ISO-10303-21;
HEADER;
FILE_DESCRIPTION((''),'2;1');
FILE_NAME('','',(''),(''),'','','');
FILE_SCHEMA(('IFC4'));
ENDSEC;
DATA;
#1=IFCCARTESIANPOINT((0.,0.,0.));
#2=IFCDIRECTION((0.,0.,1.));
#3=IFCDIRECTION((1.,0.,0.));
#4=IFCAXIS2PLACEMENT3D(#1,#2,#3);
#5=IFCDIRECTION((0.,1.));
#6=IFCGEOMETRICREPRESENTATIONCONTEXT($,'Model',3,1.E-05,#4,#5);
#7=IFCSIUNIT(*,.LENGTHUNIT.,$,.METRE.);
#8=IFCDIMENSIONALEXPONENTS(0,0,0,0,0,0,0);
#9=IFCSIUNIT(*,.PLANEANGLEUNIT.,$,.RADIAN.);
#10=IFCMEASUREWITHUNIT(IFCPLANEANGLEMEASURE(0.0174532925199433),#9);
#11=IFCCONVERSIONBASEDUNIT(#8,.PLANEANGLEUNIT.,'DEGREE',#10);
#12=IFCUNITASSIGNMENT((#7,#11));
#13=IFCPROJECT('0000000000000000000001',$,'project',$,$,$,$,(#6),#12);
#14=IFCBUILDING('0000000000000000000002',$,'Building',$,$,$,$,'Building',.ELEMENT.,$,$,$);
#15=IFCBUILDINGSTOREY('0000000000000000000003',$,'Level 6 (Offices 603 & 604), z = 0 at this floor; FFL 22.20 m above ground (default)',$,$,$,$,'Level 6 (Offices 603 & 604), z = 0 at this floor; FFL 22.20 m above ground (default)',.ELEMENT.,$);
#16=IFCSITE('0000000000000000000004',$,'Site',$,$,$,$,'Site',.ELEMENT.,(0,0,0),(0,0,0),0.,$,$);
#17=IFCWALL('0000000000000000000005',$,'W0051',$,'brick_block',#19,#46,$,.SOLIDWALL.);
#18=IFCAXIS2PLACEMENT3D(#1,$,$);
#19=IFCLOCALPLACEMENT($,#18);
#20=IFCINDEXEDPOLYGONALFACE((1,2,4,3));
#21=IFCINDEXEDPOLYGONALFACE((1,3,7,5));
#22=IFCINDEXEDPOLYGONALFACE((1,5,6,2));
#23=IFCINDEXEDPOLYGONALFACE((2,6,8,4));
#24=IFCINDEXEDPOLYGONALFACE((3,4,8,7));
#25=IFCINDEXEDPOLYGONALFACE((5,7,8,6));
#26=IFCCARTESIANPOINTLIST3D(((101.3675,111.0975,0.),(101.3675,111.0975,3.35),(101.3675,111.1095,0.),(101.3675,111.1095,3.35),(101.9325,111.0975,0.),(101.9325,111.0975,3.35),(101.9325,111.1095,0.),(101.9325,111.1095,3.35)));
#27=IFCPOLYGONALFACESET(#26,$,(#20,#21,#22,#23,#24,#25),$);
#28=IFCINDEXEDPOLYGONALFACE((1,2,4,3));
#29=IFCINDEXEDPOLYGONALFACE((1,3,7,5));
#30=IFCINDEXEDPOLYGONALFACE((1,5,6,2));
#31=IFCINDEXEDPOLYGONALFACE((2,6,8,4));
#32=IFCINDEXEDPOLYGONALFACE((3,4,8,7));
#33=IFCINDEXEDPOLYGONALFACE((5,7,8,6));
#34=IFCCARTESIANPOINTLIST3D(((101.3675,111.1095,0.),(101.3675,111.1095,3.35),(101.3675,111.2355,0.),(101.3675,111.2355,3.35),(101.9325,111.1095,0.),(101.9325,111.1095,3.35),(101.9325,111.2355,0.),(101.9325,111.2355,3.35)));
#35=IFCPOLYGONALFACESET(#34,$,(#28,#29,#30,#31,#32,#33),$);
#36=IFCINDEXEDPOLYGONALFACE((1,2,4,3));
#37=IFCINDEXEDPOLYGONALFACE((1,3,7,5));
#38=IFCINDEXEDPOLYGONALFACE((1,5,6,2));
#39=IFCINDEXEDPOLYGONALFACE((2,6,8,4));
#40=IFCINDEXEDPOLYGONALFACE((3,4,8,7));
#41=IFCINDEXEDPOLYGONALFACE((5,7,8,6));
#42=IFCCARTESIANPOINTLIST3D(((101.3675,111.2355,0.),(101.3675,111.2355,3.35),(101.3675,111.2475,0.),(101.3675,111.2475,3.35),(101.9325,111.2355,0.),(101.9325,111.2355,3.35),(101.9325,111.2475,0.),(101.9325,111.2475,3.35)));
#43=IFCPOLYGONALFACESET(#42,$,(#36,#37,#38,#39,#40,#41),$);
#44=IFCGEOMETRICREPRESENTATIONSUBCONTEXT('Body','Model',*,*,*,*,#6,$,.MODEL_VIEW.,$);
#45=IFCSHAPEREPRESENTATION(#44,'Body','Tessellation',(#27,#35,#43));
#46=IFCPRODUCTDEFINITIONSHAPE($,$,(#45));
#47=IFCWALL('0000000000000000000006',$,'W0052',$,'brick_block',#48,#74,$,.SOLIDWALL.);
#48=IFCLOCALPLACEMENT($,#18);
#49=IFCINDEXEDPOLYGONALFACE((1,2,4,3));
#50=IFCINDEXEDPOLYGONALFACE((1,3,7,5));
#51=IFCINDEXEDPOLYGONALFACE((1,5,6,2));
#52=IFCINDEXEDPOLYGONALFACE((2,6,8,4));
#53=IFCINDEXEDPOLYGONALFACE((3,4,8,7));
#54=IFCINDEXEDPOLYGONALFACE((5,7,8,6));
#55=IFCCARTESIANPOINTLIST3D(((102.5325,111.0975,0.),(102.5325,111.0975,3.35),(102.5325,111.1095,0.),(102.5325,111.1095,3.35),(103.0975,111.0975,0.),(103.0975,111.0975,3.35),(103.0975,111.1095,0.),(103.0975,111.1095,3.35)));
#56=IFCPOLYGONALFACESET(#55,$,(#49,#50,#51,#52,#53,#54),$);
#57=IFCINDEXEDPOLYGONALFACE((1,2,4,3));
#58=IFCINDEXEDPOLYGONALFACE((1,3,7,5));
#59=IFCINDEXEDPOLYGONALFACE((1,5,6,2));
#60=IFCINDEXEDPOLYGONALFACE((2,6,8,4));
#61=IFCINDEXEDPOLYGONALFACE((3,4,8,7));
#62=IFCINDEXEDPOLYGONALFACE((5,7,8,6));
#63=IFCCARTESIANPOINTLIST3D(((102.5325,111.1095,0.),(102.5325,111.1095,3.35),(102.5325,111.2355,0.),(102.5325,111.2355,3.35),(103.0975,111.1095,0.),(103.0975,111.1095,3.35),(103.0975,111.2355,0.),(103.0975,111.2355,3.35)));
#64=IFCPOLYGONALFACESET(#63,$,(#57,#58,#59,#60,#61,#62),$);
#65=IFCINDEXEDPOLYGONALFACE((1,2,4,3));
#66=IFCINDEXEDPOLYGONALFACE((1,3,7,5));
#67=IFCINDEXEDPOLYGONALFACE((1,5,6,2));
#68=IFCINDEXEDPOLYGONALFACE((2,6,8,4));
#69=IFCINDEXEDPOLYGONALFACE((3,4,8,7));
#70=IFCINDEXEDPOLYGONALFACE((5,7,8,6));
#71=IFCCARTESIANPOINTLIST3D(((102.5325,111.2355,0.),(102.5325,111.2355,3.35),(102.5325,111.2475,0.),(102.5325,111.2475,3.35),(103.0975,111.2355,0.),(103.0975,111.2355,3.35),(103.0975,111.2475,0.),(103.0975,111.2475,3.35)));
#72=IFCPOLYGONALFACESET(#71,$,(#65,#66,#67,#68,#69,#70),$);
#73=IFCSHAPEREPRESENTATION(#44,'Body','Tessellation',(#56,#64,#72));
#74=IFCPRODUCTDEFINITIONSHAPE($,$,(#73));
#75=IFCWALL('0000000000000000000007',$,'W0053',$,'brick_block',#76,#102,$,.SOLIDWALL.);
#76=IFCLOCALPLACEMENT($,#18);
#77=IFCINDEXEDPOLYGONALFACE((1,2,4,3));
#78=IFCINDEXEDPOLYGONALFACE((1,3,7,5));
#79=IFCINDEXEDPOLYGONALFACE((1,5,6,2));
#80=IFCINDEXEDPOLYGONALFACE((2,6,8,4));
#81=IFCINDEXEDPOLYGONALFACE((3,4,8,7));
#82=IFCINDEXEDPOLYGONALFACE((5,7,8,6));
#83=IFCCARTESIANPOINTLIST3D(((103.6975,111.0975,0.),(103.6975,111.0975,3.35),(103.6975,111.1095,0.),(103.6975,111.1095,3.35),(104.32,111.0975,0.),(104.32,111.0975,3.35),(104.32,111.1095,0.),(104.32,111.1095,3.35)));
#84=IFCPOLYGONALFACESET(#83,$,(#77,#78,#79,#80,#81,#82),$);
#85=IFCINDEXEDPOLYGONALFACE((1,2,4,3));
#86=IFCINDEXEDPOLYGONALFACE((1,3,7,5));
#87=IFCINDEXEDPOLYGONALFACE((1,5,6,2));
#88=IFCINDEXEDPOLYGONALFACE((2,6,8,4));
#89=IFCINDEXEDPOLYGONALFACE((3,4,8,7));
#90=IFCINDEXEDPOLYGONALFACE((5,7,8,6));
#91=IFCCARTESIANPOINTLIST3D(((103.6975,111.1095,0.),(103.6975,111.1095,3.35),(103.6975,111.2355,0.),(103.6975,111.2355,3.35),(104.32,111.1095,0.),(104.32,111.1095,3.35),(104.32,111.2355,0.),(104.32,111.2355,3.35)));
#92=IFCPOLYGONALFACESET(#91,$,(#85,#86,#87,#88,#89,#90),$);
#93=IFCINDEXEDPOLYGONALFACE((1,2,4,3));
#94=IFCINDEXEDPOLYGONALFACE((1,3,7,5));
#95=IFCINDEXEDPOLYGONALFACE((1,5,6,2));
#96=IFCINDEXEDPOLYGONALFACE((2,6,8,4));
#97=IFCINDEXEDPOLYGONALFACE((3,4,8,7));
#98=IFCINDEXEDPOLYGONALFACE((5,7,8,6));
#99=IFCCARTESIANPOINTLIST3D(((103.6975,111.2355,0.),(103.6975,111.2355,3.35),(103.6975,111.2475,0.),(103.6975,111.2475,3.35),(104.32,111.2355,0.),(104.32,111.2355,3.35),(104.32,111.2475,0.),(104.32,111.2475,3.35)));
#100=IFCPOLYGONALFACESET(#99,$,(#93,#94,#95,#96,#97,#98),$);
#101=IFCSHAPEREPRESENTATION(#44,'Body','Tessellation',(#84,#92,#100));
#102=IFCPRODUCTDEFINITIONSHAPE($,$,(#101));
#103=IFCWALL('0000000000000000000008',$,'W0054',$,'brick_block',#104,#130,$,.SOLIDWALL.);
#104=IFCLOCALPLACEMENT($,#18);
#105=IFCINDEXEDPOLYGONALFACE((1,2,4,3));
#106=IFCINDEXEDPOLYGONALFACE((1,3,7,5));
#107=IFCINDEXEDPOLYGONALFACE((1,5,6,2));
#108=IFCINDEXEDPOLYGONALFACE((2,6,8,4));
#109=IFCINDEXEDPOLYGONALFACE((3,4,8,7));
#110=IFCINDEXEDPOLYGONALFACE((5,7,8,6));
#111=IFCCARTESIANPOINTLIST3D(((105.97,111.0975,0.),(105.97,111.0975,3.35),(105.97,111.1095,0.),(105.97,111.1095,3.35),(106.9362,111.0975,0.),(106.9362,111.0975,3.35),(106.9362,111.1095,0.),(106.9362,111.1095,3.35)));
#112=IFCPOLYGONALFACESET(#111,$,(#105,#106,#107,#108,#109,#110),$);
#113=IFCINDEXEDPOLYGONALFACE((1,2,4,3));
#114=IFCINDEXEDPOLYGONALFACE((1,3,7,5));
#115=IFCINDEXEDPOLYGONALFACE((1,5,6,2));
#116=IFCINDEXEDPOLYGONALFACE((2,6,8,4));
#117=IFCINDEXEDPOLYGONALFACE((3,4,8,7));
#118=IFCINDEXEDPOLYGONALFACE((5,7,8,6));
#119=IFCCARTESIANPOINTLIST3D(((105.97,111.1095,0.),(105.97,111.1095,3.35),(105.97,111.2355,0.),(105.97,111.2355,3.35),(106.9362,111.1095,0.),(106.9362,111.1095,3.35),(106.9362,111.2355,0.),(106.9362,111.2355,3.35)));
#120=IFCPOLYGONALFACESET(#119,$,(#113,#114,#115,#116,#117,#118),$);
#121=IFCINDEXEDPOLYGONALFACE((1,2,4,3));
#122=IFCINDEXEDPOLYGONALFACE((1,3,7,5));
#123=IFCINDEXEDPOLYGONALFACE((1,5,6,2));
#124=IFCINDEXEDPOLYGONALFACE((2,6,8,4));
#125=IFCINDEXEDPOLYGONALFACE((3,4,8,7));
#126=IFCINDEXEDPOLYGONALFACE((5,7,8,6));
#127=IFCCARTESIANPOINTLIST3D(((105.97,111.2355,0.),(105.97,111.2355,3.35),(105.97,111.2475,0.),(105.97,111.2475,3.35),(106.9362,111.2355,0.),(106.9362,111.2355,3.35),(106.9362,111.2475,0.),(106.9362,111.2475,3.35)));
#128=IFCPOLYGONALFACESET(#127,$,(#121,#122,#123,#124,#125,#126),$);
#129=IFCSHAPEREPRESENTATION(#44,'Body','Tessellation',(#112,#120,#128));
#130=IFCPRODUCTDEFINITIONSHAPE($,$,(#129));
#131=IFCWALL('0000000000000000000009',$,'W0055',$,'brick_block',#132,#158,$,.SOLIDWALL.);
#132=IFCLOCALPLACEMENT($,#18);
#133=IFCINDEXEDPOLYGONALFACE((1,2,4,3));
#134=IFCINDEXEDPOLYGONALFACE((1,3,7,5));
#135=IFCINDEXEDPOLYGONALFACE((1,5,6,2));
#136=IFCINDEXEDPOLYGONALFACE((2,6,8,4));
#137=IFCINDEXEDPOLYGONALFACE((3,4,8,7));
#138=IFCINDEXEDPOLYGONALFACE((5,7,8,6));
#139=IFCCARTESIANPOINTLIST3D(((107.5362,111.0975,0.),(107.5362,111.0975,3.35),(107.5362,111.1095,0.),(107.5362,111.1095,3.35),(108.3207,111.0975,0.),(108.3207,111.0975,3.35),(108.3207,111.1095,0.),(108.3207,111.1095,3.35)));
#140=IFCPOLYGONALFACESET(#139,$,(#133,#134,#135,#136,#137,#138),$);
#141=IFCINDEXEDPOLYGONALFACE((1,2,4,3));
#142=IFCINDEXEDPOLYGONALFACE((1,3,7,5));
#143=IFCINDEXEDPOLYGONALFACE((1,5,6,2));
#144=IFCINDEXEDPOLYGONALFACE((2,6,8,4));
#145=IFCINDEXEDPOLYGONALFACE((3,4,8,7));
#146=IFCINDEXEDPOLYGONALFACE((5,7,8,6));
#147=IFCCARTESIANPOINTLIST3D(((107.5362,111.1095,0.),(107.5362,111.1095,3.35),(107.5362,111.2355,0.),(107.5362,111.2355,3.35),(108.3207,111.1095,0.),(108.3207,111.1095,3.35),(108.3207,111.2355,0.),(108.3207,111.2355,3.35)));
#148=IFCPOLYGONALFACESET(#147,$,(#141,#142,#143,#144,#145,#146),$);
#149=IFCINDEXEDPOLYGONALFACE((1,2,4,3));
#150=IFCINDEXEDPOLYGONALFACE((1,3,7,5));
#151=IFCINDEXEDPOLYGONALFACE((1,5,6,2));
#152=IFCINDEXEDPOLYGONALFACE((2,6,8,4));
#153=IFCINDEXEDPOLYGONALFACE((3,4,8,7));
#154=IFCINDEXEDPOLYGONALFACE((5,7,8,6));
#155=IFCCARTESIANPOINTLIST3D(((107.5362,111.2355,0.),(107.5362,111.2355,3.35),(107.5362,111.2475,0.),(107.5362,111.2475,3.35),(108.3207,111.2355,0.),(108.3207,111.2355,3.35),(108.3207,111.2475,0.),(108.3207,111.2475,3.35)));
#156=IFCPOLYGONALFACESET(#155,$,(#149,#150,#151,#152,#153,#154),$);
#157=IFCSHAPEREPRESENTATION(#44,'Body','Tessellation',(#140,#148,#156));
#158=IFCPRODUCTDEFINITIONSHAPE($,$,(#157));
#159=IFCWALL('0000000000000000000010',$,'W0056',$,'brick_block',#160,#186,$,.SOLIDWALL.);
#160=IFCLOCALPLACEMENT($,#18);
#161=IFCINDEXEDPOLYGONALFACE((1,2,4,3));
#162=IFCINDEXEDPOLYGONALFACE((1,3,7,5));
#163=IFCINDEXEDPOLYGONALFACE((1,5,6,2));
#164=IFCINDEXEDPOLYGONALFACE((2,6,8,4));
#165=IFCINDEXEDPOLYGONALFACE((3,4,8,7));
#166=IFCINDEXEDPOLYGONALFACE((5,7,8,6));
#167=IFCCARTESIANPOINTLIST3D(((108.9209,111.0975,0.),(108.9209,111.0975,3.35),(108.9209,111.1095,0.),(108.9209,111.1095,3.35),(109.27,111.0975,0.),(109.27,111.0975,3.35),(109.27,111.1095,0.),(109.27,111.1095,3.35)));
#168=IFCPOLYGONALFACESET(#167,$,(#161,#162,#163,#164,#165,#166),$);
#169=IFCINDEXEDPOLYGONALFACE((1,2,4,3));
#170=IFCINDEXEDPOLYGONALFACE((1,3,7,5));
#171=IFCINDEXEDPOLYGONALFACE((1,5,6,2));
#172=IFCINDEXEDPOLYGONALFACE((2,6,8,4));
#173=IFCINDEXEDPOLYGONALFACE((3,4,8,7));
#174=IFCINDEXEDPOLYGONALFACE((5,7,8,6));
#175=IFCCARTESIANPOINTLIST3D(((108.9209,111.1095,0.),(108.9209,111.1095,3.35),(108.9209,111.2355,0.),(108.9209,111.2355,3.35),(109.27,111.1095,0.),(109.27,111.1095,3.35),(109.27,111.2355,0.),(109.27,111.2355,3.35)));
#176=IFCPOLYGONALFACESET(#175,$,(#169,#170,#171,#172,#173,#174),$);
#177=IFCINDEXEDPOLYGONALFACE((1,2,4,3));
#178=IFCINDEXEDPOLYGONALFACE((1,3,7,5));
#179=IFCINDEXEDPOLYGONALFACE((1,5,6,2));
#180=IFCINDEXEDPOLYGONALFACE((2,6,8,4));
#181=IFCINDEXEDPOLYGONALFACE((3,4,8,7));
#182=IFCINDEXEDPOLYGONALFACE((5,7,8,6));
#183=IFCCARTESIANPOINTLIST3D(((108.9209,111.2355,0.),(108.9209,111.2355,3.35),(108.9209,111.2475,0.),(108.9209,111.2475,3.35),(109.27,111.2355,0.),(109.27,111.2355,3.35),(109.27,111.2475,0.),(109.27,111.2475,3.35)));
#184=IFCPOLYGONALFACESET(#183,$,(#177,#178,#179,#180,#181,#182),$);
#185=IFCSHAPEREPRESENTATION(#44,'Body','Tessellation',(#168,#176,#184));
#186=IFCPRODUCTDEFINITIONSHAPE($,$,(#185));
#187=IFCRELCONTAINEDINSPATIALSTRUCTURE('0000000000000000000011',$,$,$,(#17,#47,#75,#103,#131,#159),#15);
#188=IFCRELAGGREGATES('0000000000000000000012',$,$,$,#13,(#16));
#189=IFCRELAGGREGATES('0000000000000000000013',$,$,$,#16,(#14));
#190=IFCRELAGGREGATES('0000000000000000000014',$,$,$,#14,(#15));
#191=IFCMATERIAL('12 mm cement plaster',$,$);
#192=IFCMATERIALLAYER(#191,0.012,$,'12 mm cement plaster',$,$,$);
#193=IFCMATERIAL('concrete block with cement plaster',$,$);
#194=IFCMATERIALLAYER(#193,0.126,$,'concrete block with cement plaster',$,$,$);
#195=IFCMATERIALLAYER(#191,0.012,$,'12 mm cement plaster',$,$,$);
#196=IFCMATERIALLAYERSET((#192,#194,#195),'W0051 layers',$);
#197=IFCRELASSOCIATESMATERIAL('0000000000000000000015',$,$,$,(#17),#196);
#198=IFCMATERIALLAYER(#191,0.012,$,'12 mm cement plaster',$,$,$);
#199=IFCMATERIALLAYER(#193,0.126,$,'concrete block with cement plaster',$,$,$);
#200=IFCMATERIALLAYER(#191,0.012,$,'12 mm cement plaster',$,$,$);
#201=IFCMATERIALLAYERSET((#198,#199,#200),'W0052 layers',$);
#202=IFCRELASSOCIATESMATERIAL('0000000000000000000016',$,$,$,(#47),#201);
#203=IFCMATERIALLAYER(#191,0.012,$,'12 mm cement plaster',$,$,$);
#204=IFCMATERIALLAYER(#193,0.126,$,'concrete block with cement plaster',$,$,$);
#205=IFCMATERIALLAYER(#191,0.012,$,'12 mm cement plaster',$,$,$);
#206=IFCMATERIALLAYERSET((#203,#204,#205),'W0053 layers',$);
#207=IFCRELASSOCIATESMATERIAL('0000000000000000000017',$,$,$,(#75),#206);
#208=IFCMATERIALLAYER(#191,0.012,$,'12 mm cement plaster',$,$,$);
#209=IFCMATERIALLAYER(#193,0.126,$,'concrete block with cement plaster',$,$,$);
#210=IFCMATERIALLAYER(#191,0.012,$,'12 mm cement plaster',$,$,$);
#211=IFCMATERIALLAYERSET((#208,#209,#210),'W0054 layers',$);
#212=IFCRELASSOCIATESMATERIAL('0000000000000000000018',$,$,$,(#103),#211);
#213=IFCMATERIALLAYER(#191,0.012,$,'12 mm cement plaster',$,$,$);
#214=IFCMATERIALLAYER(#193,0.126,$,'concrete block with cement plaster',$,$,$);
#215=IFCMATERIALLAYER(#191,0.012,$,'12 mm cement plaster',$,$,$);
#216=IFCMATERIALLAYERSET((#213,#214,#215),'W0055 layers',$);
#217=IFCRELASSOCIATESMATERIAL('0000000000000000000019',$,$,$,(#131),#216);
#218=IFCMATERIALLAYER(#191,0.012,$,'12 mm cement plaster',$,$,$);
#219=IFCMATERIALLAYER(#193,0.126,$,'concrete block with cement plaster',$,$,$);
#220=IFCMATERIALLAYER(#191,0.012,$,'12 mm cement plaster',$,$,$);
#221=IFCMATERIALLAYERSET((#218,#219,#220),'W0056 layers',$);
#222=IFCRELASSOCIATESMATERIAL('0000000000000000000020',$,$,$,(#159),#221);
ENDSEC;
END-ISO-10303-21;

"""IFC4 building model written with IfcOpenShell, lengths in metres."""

from ifc_helpers import new_model, entity, si_unit, converted_unit, direction, frame, frame_2d, origin_with_axes, origin_2d_with_axis, place, context, subcontext, project, spatial, rectangle, extrude, material, layer, layer_set, layer_usage, element, save


model = new_model("IFC4")

# Units and contexts
model_context = context("Model", 3, precision=1e-05, world=origin_with_axes(), true_north=direction((0.0, 1.0)))
body_context = subcontext(model_context, "Body", "Model", "MODEL_VIEW")
ifc_project = project(units=[si_unit("LENGTHUNIT", "METRE"), converted_unit("PLANEANGLEUNIT", "DEGREE", entity("IfcPlaneAngleMeasure", 0.0174532925199433), si_unit("PLANEANGLEUNIT", "RADIAN"), dimensions=[0, 0, 0, 0, 0, 0, 0])], contexts=[model_context])

# Site, building, storey
site = spatial("IfcSite", under=ifc_project, Name="Site", LongName="Site", CompositionType="ELEMENT", RefLatitude=(0, 0, 0), RefLongitude=(0, 0, 0), RefElevation=0.0)
building = spatial("IfcBuilding", under=site, Name="Building", LongName="Building", CompositionType="ELEMENT")
storey = spatial("IfcBuildingStorey", under=building, Name="Level 6 (Offices 603 & 604), z = 0 at this floor; FFL 22.20 m above ground (default)", LongName="Level 6 (Offices 603 & 604), z = 0 at this floor; FFL 22.20 m above ground (default)", CompositionType="ELEMENT")

# Walls
ifc_material_1 = material(Name="12 mm cement plaster")
ifc_layer_1 = layer(ifc_material_1, 0.012, Name="12 mm cement plaster")
ifc_material_2 = material(Name="concrete block with cement plaster")
ifc_layer_2 = layer(ifc_material_2, 0.126, Name="concrete block with cement plaster")
ifc_layer_3 = layer(ifc_material_1, 0.012, Name="12 mm cement plaster")
ifc_layer_set_1 = layer_set([ifc_layer_1, ifc_layer_2, ifc_layer_3], Name="W0051 layers")
ifc_layer_usage_1 = layer_usage(ifc_layer_set_1, "AXIS2", "POSITIVE", -0.075)
placement = place(None, origin_with_axes())
element("IfcWall", 1, at=placement, inside=storey, material=ifc_layer_usage_1, Name="W0051", ObjectType="brick_block", PredefinedType="SOLIDWALL", context=body_context, shape_type="SweptSolid", body=[
    extrude(rectangle(XDim=0.565, YDim=0.012, at=origin_2d_with_axis()), frame((101.65, 111.1035, 0.0), z_axis=(0.0, 0.0, 1.0), x_axis=(1.0, 0.0, 0.0)), (0.0, 0.0, 1.0), 3.35),
    extrude(rectangle(XDim=0.565, YDim=0.126, at=frame_2d((0.0, 0.069), x_axis=(1.0, 0.0))), frame((101.65, 111.1035, 0.0), z_axis=(0.0, 0.0, 1.0), x_axis=(1.0, 0.0, 0.0)), (0.0, 0.0, 1.0), 3.35),
    extrude(rectangle(XDim=0.565, YDim=0.012, at=frame_2d((0.0, 0.138), x_axis=(1.0, 0.0))), frame((101.65, 111.1035, 0.0), z_axis=(0.0, 0.0, 1.0), x_axis=(1.0, 0.0, 0.0)), (0.0, 0.0, 1.0), 3.35),
])
ifc_layer_4 = layer(ifc_material_1, 0.012, Name="12 mm cement plaster")
ifc_layer_5 = layer(ifc_material_2, 0.126, Name="concrete block with cement plaster")
ifc_layer_6 = layer(ifc_material_1, 0.012, Name="12 mm cement plaster")
ifc_layer_set_2 = layer_set([ifc_layer_4, ifc_layer_5, ifc_layer_6], Name="W0052 layers")
ifc_layer_usage_2 = layer_usage(ifc_layer_set_2, "AXIS2", "POSITIVE", -0.075)
element("IfcWall", 2, at=placement, inside=storey, material=ifc_layer_usage_2, Name="W0052", ObjectType="brick_block", PredefinedType="SOLIDWALL", context=body_context, shape_type="SweptSolid", body=[
    extrude(rectangle(XDim=0.565, YDim=0.012, at=origin_2d_with_axis()), frame((102.815, 111.1035, 0.0), z_axis=(0.0, 0.0, 1.0), x_axis=(1.0, 0.0, 0.0)), (0.0, 0.0, 1.0), 3.35),
    extrude(rectangle(XDim=0.565, YDim=0.126, at=frame_2d((0.0, 0.069), x_axis=(1.0, 0.0))), frame((102.815, 111.1035, 0.0), z_axis=(0.0, 0.0, 1.0), x_axis=(1.0, 0.0, 0.0)), (0.0, 0.0, 1.0), 3.35),
    extrude(rectangle(XDim=0.565, YDim=0.012, at=frame_2d((0.0, 0.138), x_axis=(1.0, 0.0))), frame((102.815, 111.1035, 0.0), z_axis=(0.0, 0.0, 1.0), x_axis=(1.0, 0.0, 0.0)), (0.0, 0.0, 1.0), 3.35),
])
ifc_layer_7 = layer(ifc_material_1, 0.012, Name="12 mm cement plaster")
ifc_layer_8 = layer(ifc_material_2, 0.126, Name="concrete block with cement plaster")
ifc_layer_9 = layer(ifc_material_1, 0.012, Name="12 mm cement plaster")
ifc_layer_set_3 = layer_set([ifc_layer_7, ifc_layer_8, ifc_layer_9], Name="W0053 layers")
ifc_layer_usage_3 = layer_usage(ifc_layer_set_3, "AXIS2", "POSITIVE", -0.075)
element("IfcWall", 3, at=placement, inside=storey, material=ifc_layer_usage_3, Name="W0053", ObjectType="brick_block", PredefinedType="SOLIDWALL", context=body_context, shape_type="SweptSolid", body=[
    extrude(rectangle(XDim=0.6225, YDim=0.012, at=frame_2d((0.0, 0.0), x_axis=(1.0, 0.0))), frame((104.0088, 111.1035, 0.0), z_axis=(0.0, 0.0, 1.0), x_axis=(1.0, 0.0, 0.0)), (0.0, 0.0, 1.0), 3.35),
    extrude(rectangle(XDim=0.6225, YDim=0.126, at=frame_2d((0.0, 0.069), x_axis=(1.0, 0.0))), frame((104.0088, 111.1035, 0.0), z_axis=(0.0, 0.0, 1.0), x_axis=(1.0, 0.0, 0.0)), (0.0, 0.0, 1.0), 3.35),
    extrude(rectangle(XDim=0.6225, YDim=0.012, at=frame_2d((0.0, 0.138), x_axis=(1.0, 0.0))), frame((104.0088, 111.1035, 0.0), z_axis=(0.0, 0.0, 1.0), x_axis=(1.0, 0.0, 0.0)), (0.0, 0.0, 1.0), 3.35),
])
ifc_layer_10 = layer(ifc_material_1, 0.012, Name="12 mm cement plaster")
ifc_layer_11 = layer(ifc_material_2, 0.126, Name="concrete block with cement plaster")
ifc_layer_12 = layer(ifc_material_1, 0.012, Name="12 mm cement plaster")
ifc_layer_set_4 = layer_set([ifc_layer_10, ifc_layer_11, ifc_layer_12], Name="W0054 layers")
ifc_layer_usage_4 = layer_usage(ifc_layer_set_4, "AXIS2", "POSITIVE", -0.075)
element("IfcWall", 4, at=placement, inside=storey, material=ifc_layer_usage_4, Name="W0054", ObjectType="brick_block", PredefinedType="SOLIDWALL", context=body_context, shape_type="SweptSolid", body=[
    extrude(rectangle(XDim=0.9662, YDim=0.012, at=frame_2d((0.0, 0.0), x_axis=(1.0, 0.0))), frame((106.4531, 111.1035, 0.0), z_axis=(0.0, 0.0, 1.0), x_axis=(1.0, 0.0, 0.0)), (0.0, 0.0, 1.0), 3.35),
    extrude(rectangle(XDim=0.9662, YDim=0.126, at=frame_2d((0.0, 0.069), x_axis=(1.0, 0.0))), frame((106.4531, 111.1035, 0.0), z_axis=(0.0, 0.0, 1.0), x_axis=(1.0, 0.0, 0.0)), (0.0, 0.0, 1.0), 3.35),
    extrude(rectangle(XDim=0.9662, YDim=0.012, at=frame_2d((0.0, 0.138), x_axis=(1.0, 0.0))), frame((106.4531, 111.1035, 0.0), z_axis=(0.0, 0.0, 1.0), x_axis=(1.0, 0.0, 0.0)), (0.0, 0.0, 1.0), 3.35),
])
ifc_layer_13 = layer(ifc_material_1, 0.012, Name="12 mm cement plaster")
ifc_layer_14 = layer(ifc_material_2, 0.126, Name="concrete block with cement plaster")
ifc_layer_15 = layer(ifc_material_1, 0.012, Name="12 mm cement plaster")
ifc_layer_set_5 = layer_set([ifc_layer_13, ifc_layer_14, ifc_layer_15], Name="W0055 layers")
ifc_layer_usage_5 = layer_usage(ifc_layer_set_5, "AXIS2", "POSITIVE", -0.075)
element("IfcWall", 5, at=placement, inside=storey, material=ifc_layer_usage_5, Name="W0055", ObjectType="brick_block", PredefinedType="SOLIDWALL", context=body_context, shape_type="SweptSolid", body=[
    extrude(rectangle(XDim=0.7845, YDim=0.012, at=origin_2d_with_axis()), frame((107.9284, 111.1035, 0.0), z_axis=(0.0, 0.0, 1.0), x_axis=(1.0, 0.0, 0.0)), (0.0, 0.0, 1.0), 3.35),
    extrude(rectangle(XDim=0.7845, YDim=0.126, at=frame_2d((0.0, 0.069), x_axis=(1.0, 0.0))), frame((107.9284, 111.1035, 0.0), z_axis=(0.0, 0.0, 1.0), x_axis=(1.0, 0.0, 0.0)), (0.0, 0.0, 1.0), 3.35),
    extrude(rectangle(XDim=0.7845, YDim=0.012, at=frame_2d((0.0, 0.138), x_axis=(1.0, 0.0))), frame((107.9284, 111.1035, 0.0), z_axis=(0.0, 0.0, 1.0), x_axis=(1.0, 0.0, 0.0)), (0.0, 0.0, 1.0), 3.35),
])
ifc_layer_16 = layer(ifc_material_1, 0.012, Name="12 mm cement plaster")
ifc_layer_17 = layer(ifc_material_2, 0.126, Name="concrete block with cement plaster")
ifc_layer_18 = layer(ifc_material_1, 0.012, Name="12 mm cement plaster")
ifc_layer_set_6 = layer_set([ifc_layer_16, ifc_layer_17, ifc_layer_18], Name="W0056 layers")
ifc_layer_usage_6 = layer_usage(ifc_layer_set_6, "AXIS2", "POSITIVE", -0.075)
element("IfcWall", 6, at=placement, inside=storey, material=ifc_layer_usage_6, Name="W0056", ObjectType="brick_block", PredefinedType="SOLIDWALL", context=body_context, shape_type="SweptSolid", body=[
    extrude(rectangle(XDim=0.3491, YDim=0.012, at=frame_2d((0.0, 0.0), x_axis=(1.0, 0.0))), frame((109.0954, 111.1035, 0.0), z_axis=(0.0, 0.0, 1.0), x_axis=(1.0, 0.0, 0.0)), (0.0, 0.0, 1.0), 3.35),
    extrude(rectangle(XDim=0.3491, YDim=0.126, at=frame_2d((0.0, 0.069), x_axis=(1.0, 0.0))), frame((109.0954, 111.1035, 0.0), z_axis=(0.0, 0.0, 1.0), x_axis=(1.0, 0.0, 0.0)), (0.0, 0.0, 1.0), 3.35),
    extrude(rectangle(XDim=0.3491, YDim=0.012, at=frame_2d((0.0, 0.138), x_axis=(1.0, 0.0))), frame((109.0954, 111.1035, 0.0), z_axis=(0.0, 0.0, 1.0), x_axis=(1.0, 0.0, 0.0)), (0.0, 0.0, 1.0), 3.35),
])

save(model, "model.ifc")
